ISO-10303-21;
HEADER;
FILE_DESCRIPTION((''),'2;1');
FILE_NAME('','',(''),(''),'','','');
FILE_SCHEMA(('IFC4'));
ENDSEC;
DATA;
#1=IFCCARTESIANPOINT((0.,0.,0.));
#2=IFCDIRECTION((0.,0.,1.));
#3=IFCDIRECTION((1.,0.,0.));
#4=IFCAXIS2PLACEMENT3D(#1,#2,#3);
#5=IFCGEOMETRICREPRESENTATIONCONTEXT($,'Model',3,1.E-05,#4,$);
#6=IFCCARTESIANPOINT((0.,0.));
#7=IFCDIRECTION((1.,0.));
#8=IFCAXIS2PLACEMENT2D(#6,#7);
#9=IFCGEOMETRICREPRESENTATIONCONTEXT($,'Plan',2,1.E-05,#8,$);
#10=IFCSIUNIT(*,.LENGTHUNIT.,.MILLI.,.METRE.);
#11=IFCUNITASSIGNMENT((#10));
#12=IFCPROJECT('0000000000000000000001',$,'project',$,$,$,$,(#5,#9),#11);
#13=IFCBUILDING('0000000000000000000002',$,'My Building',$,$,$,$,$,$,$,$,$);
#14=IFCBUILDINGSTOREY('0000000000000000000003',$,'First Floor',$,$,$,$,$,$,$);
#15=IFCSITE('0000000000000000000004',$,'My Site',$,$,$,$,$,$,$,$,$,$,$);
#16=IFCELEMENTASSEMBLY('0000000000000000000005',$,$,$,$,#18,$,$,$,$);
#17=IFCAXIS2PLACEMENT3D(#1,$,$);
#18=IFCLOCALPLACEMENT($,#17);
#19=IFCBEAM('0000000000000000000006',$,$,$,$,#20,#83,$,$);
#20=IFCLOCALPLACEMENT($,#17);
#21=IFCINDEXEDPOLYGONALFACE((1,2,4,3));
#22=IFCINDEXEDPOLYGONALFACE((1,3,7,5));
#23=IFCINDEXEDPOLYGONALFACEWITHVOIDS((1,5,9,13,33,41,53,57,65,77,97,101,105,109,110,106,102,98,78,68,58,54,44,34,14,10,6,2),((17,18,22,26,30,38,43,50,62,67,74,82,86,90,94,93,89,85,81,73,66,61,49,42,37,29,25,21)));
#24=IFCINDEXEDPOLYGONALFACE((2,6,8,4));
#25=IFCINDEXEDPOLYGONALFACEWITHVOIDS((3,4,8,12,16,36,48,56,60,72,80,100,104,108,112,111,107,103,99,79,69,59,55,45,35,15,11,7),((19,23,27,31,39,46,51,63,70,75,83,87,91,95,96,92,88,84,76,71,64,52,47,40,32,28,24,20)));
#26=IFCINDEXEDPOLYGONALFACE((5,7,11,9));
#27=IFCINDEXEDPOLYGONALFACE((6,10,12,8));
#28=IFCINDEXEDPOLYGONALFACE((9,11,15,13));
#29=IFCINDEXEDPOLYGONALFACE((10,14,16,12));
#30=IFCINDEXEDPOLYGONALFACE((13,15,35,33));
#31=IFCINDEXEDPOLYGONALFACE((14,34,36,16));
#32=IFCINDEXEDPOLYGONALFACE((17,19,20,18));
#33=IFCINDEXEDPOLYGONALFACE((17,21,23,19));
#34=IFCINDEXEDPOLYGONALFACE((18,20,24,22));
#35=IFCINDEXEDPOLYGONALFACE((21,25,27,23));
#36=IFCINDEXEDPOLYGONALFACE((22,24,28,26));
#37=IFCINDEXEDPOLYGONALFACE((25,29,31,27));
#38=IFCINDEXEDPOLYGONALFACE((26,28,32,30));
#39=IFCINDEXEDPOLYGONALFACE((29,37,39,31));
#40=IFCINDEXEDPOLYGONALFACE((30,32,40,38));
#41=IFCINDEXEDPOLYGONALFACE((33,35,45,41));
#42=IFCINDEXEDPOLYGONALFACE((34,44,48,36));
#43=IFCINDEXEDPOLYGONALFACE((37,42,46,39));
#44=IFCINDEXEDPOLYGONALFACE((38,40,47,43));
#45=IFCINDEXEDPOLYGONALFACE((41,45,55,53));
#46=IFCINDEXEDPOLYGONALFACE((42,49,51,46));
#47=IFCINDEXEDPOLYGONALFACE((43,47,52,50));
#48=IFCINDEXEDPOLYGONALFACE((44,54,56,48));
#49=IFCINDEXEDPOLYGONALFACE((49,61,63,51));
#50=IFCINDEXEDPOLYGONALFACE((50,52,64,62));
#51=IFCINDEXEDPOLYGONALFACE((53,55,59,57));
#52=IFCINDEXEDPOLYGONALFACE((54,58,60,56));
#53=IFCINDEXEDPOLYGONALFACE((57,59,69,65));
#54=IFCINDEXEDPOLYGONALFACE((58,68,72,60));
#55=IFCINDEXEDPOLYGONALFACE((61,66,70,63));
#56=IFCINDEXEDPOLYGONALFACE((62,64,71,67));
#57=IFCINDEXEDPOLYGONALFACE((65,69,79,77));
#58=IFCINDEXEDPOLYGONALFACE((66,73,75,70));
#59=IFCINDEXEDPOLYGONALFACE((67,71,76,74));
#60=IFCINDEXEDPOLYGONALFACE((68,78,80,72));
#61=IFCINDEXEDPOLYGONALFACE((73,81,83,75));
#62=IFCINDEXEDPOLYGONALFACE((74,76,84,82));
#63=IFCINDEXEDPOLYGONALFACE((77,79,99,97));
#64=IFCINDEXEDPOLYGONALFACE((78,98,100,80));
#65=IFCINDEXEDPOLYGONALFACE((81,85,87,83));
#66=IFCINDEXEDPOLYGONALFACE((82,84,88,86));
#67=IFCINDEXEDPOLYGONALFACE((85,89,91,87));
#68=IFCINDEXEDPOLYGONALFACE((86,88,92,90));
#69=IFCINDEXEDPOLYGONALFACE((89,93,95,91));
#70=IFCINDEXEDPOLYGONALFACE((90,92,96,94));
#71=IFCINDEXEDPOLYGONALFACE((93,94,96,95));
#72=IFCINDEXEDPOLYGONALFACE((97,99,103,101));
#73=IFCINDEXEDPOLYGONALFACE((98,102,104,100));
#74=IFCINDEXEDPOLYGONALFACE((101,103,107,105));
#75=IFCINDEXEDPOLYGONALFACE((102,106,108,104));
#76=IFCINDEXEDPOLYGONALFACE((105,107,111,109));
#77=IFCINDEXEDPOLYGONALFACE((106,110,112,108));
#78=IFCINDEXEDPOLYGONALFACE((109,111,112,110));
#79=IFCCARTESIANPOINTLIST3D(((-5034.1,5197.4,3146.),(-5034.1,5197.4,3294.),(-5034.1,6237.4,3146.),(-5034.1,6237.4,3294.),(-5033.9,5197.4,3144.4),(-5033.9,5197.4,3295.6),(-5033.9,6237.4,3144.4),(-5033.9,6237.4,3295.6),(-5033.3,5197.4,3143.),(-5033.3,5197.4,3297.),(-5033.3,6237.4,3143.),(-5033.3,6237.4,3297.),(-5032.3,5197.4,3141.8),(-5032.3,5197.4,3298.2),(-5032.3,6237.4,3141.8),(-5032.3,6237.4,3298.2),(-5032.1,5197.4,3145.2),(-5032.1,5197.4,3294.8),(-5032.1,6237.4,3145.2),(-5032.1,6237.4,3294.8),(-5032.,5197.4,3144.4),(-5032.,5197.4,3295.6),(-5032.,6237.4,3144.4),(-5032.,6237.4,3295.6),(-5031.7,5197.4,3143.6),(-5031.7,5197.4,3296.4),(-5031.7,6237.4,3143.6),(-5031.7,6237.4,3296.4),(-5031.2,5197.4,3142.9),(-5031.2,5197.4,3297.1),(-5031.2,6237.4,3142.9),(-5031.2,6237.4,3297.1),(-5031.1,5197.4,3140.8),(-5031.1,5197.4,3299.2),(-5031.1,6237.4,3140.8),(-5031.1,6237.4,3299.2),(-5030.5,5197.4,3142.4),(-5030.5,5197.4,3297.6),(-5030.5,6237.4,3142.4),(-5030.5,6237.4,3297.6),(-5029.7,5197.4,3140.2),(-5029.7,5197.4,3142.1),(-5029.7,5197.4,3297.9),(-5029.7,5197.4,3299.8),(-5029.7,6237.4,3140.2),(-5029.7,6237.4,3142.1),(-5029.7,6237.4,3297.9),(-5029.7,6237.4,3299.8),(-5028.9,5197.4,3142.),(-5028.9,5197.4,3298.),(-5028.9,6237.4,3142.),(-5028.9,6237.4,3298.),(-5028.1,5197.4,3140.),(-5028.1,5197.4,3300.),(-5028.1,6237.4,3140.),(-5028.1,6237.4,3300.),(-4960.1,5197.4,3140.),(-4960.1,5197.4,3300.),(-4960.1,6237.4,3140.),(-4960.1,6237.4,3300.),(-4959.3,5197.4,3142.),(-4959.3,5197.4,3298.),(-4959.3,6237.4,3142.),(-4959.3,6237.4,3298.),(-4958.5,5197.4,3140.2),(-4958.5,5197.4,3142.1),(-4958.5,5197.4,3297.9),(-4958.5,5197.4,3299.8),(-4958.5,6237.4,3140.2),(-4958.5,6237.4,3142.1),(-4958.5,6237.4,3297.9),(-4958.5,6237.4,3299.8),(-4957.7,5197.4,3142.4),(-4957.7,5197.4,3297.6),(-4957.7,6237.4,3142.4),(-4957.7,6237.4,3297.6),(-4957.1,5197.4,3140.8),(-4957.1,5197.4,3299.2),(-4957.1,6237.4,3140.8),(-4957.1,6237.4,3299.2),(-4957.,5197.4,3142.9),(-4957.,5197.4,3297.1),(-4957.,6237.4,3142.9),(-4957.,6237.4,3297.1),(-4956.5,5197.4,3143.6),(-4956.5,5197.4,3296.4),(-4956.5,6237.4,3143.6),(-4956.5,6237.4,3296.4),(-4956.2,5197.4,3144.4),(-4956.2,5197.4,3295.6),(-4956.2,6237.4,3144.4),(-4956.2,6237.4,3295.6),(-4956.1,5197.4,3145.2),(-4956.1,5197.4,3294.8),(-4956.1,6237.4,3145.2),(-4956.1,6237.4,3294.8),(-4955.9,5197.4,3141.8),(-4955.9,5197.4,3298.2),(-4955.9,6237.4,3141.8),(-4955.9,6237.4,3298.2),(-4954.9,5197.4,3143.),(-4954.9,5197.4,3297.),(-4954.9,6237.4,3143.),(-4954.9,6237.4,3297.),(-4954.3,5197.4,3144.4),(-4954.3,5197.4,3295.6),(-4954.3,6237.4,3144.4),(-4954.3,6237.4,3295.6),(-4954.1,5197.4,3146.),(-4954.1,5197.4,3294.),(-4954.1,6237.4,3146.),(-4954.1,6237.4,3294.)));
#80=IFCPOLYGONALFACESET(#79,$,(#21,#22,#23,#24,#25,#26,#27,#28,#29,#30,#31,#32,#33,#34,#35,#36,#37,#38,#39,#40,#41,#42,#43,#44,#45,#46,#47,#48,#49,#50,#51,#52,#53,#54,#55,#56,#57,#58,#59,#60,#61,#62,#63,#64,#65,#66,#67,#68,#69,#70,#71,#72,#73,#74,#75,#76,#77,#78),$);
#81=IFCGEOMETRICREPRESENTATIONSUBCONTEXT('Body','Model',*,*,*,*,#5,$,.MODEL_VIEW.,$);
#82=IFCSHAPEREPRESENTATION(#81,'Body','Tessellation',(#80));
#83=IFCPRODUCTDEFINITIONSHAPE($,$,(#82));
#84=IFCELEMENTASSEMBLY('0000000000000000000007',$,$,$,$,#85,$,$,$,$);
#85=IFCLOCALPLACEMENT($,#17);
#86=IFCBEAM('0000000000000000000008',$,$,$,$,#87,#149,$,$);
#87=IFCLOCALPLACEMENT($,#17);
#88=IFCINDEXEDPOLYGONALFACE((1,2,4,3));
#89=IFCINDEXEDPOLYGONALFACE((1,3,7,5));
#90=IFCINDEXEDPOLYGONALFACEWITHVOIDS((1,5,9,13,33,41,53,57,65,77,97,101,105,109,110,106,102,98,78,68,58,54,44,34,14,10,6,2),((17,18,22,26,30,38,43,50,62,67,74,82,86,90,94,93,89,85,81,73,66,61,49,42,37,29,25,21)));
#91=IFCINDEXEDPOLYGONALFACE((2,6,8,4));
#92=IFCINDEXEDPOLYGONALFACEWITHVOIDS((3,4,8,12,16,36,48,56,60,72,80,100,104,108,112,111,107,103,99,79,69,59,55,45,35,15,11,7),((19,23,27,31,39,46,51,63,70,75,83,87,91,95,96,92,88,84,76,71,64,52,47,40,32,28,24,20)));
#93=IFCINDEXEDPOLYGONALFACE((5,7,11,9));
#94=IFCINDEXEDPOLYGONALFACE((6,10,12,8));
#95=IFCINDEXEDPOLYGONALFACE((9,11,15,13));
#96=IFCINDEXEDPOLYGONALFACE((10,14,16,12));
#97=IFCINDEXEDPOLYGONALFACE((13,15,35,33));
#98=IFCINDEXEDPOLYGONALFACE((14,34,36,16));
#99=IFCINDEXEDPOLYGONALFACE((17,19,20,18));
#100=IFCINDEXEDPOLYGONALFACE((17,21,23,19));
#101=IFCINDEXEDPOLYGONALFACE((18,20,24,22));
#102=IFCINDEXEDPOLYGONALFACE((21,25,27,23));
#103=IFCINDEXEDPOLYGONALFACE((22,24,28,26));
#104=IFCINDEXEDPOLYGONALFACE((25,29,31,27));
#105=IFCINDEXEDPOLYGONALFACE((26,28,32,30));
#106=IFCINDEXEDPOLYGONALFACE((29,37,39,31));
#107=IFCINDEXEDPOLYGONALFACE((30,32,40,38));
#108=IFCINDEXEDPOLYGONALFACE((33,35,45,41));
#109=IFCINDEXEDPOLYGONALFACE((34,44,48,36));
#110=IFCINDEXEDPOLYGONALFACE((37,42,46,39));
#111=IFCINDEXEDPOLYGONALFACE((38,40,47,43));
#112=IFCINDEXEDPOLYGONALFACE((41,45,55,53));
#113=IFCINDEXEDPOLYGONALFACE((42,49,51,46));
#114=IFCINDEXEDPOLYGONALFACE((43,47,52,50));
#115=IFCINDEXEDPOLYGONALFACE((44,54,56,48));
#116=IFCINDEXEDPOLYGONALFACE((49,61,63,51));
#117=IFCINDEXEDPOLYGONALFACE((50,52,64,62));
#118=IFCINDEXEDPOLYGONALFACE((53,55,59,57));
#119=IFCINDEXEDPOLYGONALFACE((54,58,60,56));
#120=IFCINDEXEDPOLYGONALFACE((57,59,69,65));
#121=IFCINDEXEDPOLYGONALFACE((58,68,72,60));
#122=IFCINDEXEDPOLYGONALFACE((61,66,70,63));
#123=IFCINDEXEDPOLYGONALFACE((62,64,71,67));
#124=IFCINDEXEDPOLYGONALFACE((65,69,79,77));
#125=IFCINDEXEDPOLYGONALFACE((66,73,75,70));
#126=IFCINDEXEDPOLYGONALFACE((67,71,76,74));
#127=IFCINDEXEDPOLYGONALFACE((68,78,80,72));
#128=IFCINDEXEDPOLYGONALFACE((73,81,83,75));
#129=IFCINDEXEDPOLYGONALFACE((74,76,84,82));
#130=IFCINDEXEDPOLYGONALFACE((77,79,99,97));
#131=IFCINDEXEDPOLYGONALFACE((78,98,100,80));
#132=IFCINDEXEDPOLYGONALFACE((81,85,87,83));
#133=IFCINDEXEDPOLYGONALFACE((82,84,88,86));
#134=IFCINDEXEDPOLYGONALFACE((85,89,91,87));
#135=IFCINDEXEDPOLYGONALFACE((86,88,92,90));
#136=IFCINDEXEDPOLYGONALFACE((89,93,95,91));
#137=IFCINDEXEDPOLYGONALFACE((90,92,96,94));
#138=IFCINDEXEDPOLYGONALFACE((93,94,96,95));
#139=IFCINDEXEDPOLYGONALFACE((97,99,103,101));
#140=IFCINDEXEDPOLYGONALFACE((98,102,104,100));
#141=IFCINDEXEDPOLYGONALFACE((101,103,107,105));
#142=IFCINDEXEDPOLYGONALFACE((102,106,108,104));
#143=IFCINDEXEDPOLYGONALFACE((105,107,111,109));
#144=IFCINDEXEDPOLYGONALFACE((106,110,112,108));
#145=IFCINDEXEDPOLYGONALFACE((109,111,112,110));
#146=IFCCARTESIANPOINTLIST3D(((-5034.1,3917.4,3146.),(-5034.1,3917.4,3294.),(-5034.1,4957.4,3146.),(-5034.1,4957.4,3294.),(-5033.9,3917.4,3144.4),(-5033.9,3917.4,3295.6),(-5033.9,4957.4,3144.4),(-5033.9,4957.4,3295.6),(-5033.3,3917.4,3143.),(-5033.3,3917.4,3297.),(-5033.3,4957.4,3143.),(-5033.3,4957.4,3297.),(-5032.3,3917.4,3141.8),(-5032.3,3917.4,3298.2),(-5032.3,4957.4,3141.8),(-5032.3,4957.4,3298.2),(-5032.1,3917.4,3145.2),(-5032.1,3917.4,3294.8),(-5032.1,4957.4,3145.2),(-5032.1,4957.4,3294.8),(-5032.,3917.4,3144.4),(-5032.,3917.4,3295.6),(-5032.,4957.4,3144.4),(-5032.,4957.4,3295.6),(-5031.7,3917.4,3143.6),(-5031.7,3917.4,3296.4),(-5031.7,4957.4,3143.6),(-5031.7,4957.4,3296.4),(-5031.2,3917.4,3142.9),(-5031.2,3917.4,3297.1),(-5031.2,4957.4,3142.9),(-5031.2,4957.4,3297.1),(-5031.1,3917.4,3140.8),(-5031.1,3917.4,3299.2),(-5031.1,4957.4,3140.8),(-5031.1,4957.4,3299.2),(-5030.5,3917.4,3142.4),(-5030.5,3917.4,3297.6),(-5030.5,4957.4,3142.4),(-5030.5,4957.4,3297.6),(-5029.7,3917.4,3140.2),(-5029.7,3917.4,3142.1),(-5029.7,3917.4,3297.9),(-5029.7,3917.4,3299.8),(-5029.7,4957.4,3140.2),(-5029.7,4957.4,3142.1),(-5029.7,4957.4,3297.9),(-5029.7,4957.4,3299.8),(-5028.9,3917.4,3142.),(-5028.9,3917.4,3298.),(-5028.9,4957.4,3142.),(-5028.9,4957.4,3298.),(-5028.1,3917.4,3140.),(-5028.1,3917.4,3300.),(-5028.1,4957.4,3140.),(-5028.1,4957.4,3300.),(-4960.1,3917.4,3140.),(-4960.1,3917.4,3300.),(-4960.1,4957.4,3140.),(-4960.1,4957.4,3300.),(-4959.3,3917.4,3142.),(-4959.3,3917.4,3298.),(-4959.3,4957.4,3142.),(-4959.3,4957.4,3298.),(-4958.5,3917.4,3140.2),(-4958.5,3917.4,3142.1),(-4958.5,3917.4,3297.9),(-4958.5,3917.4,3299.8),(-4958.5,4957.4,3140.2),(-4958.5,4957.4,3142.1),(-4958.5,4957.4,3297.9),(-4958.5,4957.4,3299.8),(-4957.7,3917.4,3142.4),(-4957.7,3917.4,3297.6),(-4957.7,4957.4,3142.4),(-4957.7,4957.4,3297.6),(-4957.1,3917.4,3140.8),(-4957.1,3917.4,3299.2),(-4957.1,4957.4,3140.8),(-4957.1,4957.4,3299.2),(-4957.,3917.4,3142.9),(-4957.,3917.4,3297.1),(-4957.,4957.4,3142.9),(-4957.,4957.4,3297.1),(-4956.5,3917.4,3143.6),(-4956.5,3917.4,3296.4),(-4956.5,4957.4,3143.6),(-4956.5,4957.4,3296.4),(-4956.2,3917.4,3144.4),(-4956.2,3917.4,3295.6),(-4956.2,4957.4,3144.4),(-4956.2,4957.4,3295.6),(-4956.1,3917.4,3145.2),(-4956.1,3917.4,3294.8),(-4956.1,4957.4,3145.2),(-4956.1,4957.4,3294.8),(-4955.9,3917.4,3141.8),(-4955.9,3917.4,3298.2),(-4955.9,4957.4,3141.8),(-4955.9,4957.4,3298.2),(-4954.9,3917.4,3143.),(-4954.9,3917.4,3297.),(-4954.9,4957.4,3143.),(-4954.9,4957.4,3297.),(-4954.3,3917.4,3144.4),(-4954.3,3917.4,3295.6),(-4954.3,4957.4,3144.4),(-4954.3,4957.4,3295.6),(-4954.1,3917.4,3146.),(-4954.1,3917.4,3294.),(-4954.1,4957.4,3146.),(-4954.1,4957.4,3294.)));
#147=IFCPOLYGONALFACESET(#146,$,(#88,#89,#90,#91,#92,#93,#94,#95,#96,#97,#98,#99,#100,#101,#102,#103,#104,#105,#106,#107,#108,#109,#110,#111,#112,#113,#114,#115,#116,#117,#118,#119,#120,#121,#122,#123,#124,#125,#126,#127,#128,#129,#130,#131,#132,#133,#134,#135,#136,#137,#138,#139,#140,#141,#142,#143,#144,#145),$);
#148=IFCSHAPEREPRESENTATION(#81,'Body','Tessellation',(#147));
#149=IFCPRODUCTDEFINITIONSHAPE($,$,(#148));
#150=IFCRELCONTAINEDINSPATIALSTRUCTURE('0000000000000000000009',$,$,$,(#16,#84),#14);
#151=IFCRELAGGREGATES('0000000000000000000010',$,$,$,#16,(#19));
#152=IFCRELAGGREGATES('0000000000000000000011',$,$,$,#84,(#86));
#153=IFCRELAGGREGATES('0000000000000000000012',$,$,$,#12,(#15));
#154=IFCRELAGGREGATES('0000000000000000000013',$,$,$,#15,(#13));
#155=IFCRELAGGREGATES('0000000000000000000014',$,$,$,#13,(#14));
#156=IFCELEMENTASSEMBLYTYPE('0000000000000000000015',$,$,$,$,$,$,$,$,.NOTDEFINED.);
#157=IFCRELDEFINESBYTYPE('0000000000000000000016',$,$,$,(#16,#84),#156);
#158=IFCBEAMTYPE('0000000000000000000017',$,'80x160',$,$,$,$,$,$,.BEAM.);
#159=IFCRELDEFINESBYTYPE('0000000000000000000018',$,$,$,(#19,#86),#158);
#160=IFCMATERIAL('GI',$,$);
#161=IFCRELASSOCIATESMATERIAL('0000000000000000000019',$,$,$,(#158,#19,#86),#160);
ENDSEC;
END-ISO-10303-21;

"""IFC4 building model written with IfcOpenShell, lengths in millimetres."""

from ifc_helpers import new_model, si_unit, frame, origin_with_axes, origin_2d_with_axis, place, context, subcontext, project, spatial, hollow_rectangle, extrude, material, material_profile, profile_set, profile_usage, type_object, element, aggregate, save


model = new_model("IFC4")

# Units and contexts
model_context = context("Model", 3, precision=1e-05, world=origin_with_axes())
plan_context = context("Plan", 2, precision=1e-05, world=origin_2d_with_axis())
body_context = subcontext(model_context, "Body", "Model", "MODEL_VIEW")
ifc_project = project(units=[si_unit("LENGTHUNIT", "METRE", prefix="MILLI")], contexts=[model_context, plan_context])

# Site, building, storey
site = spatial("IfcSite", under=ifc_project, Name="My Site")
building = spatial("IfcBuilding", under=site, Name="My Building")
storey = spatial("IfcBuildingStorey", under=building, Name="First Floor")

# Element assemblies, beams
element_assembly_type = type_object("IfcElementAssemblyType", PredefinedType="NOTDEFINED")
ifc_material = material(Name="GI")
ifc_material_profile = material_profile(ifc_material, hollow_rectangle(XDim=80.0, YDim=160.0, WallThickness=2.0, InnerFilletRadius=3.2, OuterFilletRadius=6.0))
ifc_profile_set = profile_set([ifc_material_profile], Name="80x160 GI Rectangular Hollow")
beam_type = type_object("IfcBeamType", Name="80x160", PredefinedType="BEAM", material=ifc_profile_set)
assembly_1_placement = place(None, frame((-4994.1, 5117.4, 3220.0), z_axis=(0.0, 1.0, 0.0), x_axis=(1.0, 0.0, 0.0)))
assembly_1 = element("IfcElementAssembly", 1, at=assembly_1_placement, inside=storey, type_object=element_assembly_type)
ifc_profile_usage_1 = profile_usage(ifc_profile_set)
beam_1_placement = place(assembly_1_placement, frame((0.0, 0.0, 80.0), z_axis=(0.0, 0.0, 1.0), x_axis=(1.0, 0.0, 0.0)))
beam_1 = element("IfcBeam", 2, at=beam_1_placement, type_object=beam_type, material=ifc_profile_usage_1, context=body_context, shape_type="SweptSolid", body=[
    extrude(hollow_rectangle(XDim=80.0, YDim=160.0, WallThickness=2.0, InnerFilletRadius=3.2, OuterFilletRadius=6.0), origin_with_axes(), (0.0, 0.0, 1.0), 1040.0),
])
aggregate(assembly_1, [beam_1])
assembly_2_placement = place(None, frame((-4994.1, 3837.4, 3220.0), z_axis=(0.0, 1.0, 0.0), x_axis=(1.0, 0.0, 0.0)))
assembly_2 = element("IfcElementAssembly", 3, at=assembly_2_placement, inside=storey, type_object=element_assembly_type)
ifc_profile_usage_2 = profile_usage(ifc_profile_set)
beam_2_placement = place(assembly_2_placement, frame((0.0, 0.0, 80.0), z_axis=(0.0, 0.0, 1.0), x_axis=(1.0, 0.0, 0.0)))
beam_2 = element("IfcBeam", 4, at=beam_2_placement, type_object=beam_type, material=ifc_profile_usage_2, context=body_context, shape_type="SweptSolid", body=[
    extrude(hollow_rectangle(XDim=80.0, YDim=160.0, WallThickness=2.0, InnerFilletRadius=3.2, OuterFilletRadius=6.0), origin_with_axes(), (0.0, 0.0, 1.0), 1040.0),
])
aggregate(assembly_2, [beam_2])

save(model, "model.ifc")
